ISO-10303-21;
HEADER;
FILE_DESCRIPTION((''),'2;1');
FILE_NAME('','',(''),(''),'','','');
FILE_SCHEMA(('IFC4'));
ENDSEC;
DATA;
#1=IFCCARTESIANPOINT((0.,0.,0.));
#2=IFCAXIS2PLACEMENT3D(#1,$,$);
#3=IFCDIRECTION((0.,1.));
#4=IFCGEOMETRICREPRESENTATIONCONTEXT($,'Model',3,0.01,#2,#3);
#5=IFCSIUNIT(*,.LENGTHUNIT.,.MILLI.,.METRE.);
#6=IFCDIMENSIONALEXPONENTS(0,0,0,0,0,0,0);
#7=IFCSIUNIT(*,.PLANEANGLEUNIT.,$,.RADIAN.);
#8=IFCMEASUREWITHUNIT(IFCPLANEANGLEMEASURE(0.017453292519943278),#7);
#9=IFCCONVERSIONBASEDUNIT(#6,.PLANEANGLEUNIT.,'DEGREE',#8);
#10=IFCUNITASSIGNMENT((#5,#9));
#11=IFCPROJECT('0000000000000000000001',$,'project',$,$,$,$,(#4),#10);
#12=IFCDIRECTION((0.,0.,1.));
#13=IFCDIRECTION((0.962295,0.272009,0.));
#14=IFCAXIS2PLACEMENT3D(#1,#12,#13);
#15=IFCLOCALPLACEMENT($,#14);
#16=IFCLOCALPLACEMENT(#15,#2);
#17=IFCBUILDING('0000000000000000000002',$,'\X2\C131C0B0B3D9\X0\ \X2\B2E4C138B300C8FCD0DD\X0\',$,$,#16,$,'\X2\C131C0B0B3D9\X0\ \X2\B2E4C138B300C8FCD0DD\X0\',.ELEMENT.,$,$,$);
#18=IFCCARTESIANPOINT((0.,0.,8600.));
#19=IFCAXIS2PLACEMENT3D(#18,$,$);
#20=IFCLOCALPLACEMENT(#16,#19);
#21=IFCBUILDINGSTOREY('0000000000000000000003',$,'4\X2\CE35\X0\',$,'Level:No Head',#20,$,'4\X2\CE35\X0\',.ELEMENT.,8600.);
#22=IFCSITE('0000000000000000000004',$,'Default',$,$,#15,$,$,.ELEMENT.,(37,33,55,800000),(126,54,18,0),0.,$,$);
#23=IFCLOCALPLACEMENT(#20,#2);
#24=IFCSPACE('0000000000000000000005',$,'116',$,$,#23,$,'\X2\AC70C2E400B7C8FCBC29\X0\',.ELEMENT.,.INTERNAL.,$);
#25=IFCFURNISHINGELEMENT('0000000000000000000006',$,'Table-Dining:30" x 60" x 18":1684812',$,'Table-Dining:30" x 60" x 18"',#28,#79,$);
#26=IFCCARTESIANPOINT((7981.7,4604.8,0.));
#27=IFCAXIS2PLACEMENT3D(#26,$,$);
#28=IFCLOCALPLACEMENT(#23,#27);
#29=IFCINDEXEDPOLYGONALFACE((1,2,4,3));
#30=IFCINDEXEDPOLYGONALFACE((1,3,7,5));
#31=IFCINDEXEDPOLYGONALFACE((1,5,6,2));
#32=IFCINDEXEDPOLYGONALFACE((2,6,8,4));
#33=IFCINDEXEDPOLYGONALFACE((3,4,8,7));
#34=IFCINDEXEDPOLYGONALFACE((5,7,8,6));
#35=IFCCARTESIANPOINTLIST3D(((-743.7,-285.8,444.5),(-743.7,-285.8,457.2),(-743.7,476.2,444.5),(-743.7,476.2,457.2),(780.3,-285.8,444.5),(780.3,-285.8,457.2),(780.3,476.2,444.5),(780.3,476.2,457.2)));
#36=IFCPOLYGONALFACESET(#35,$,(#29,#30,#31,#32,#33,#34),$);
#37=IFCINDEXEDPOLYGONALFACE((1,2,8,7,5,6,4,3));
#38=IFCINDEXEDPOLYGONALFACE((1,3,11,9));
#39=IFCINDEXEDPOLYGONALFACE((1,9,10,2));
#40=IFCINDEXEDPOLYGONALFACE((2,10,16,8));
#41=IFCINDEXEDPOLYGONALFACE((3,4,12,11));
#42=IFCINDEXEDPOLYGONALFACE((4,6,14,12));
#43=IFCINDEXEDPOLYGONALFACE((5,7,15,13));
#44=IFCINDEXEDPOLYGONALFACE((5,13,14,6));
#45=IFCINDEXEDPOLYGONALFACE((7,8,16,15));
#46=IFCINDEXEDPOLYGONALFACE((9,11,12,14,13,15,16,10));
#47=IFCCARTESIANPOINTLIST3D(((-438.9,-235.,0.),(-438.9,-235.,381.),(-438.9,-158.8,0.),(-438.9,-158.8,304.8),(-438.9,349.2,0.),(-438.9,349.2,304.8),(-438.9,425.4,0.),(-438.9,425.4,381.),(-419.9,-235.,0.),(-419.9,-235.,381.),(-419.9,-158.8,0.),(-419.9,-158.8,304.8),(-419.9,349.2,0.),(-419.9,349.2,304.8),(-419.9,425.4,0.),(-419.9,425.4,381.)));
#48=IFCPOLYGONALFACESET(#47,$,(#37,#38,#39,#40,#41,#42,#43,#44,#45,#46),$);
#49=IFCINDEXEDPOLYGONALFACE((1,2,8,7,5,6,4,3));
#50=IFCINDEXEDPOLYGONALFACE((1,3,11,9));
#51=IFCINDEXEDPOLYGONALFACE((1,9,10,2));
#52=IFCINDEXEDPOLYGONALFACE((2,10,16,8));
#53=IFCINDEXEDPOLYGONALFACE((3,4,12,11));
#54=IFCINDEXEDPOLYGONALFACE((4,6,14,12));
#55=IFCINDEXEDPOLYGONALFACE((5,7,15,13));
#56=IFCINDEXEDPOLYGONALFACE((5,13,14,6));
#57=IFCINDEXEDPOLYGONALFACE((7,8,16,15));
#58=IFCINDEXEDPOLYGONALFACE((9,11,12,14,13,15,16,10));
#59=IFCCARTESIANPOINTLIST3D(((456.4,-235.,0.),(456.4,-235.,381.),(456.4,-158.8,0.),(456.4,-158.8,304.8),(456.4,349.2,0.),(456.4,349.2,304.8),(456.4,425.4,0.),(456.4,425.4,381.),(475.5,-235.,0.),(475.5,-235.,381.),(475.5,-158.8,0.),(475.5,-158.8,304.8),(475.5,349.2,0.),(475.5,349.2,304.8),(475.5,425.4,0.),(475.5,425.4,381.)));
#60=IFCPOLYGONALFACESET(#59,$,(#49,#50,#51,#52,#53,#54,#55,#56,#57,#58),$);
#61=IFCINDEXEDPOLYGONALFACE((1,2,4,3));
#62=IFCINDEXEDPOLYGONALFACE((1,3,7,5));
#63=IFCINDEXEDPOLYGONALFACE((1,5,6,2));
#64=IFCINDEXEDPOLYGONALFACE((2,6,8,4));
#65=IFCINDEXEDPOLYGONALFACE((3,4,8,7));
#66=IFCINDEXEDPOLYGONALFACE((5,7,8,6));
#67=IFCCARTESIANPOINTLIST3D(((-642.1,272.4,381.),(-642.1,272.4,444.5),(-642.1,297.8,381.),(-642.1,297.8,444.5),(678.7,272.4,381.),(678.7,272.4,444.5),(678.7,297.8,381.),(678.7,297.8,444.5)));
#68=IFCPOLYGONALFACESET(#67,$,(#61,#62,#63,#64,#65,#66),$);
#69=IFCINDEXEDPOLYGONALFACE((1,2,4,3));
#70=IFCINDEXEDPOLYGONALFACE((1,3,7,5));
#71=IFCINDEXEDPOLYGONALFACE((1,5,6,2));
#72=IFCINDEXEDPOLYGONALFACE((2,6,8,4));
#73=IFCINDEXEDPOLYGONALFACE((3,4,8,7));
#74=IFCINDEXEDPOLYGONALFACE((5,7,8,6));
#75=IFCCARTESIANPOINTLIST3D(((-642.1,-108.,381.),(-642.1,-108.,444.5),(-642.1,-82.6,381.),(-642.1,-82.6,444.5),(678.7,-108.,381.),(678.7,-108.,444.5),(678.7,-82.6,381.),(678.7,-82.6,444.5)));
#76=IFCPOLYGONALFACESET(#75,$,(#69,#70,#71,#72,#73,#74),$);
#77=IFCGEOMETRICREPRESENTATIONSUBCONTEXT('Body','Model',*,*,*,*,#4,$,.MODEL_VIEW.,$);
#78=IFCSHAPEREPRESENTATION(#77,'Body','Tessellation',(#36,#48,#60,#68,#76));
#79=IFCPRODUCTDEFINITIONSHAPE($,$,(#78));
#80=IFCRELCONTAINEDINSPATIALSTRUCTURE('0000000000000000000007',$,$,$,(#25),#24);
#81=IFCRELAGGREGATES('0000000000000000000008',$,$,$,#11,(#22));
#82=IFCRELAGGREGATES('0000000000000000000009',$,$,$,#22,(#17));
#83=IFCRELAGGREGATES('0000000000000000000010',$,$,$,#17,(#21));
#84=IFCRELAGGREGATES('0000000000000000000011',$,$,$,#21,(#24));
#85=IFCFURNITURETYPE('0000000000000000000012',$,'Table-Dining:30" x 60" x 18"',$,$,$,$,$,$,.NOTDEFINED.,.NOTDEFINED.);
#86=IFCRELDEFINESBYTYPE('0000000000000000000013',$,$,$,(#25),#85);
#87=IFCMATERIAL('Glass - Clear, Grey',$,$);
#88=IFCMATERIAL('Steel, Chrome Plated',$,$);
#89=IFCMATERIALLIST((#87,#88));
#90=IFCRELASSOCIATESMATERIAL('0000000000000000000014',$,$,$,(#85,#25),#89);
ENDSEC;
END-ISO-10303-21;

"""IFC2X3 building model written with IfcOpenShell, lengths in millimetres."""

from ifc_helpers import new_model, entity, si_unit, converted_unit, direction, frame, frame_2d, origin, origin_2d_with_axis, place, context, subcontext, project, spatial, polyline, rectangle, outline, extrude, source, transform, mapped, material, material_list, type_object, type_shapes, element, save


model = new_model("IFC2X3")

# Units and contexts
model_context = context("Model", 3, precision=0.01, world=origin(), true_north=direction((0.0, 1.0)))
body_context = subcontext(model_context, "Body", "Model", "MODEL_VIEW")
ifc_project = project(units=[si_unit("LENGTHUNIT", "METRE", prefix="MILLI"), converted_unit("PLANEANGLEUNIT", "DEGREE", entity("IfcPlaneAngleMeasure", 0.017453292519943278), si_unit("PLANEANGLEUNIT", "RADIAN"), dimensions=[0, 0, 0, 0, 0, 0, 0])], contexts=[model_context])

# Site, building, storey
site_placement = place(None, frame((0.0, 0.0, 0.0), z_axis=(0.0, 0.0, 1.0), x_axis=(0.962295, 0.272009, 0.0)))
site = spatial("IfcSite", under=ifc_project, at=site_placement, Name="Default", CompositionType="ELEMENT", RefLatitude=(37, 33, 55, 800000), RefLongitude=(126, 54, 18, 0), RefElevation=0.0)
building_placement = place(site_placement, origin())
building = spatial("IfcBuilding", under=site, at=building_placement, Name="성산동 다세대주택", LongName="성산동 다세대주택", CompositionType="ELEMENT")
storey_placement = place(building_placement, frame((0.0, 0.0, 8600.0)))
storey = spatial("IfcBuildingStorey", under=building, at=storey_placement, Name="4층", ObjectType="Level:No Head", LongName="4층", CompositionType="ELEMENT", Elevation=8600.0)

# Shared definitions
space_1_placement = place(storey_placement, origin())
space_1 = spatial("IfcSpace", under=storey, at=space_1_placement, Name="116", LongName="거실·주방", CompositionType="ELEMENT", InteriorOrExteriorSpace="INTERNAL")

# Furnishing element
ifc_material_1 = material(Name="Glass - Clear, Grey")
ifc_material_2 = material(Name="Steel, Chrome Plated")
ifc_material_list_1 = material_list([ifc_material_1, ifc_material_2])
furniture_type_1 = type_object("IfcFurnitureType", Name="Table-Dining:30\" x 60\" x 18\"", AssemblyPlace="NOTDEFINED", material=ifc_material_list_1)
shared_shape_1 = source(origin(), body_context, "Body", "SweptSolid", [
    extrude(rectangle(XDim=1524.0, YDim=762.0, at=frame_2d((0.0, 0.0), x_axis=(1.0, 0.0))), frame((18.3, 95.2, 444.5), z_axis=(0.0, 0.0, 1.0), x_axis=(-1.0, 0.0, 0.0)), (0.0, 0.0, 1.0), 12.7),
    extrude(outline(polyline([(-330.2, -209.5), (330.2, -209.5), (330.2, 171.4), (254.0, 171.4), (254.0, -133.3), (-254.0, -133.3), (-254.0, 171.4), (-330.2, 171.4), (-330.2, -209.5)])), frame((-438.9, 95.2, 171.4), z_axis=(1.0, 0.0, 0.0), x_axis=(0.0, -1.0, 0.0)), (0.0, 0.0, 1.0), 19.1),
    extrude(outline(polyline([(-171.4, -330.2), (209.5, -330.2), (209.5, 330.2), (-171.4, 330.2), (-171.4, 254.0), (133.3, 254.0), (133.3, -254.0), (-171.4, -254.0), (-171.4, -330.2)])), frame((456.4, 95.2, 171.4), z_axis=(1.0, 0.0, 0.0), x_axis=(0.0, 0.0, 1.0)), (0.0, 0.0, 1.0), 19.1),
    extrude(rectangle(XDim=1320.8, YDim=25.4, at=frame_2d((0.0, 0.0), x_axis=(1.0, 0.0))), frame((18.3, 285.1, 381.0), z_axis=(0.0, 0.0, 1.0), x_axis=(-1.0, 0.0, 0.0)), (0.0, 0.0, 1.0), 63.5),
    extrude(rectangle(XDim=1320.8, YDim=25.4, at=origin_2d_with_axis()), frame((18.3, -95.3, 381.0), z_axis=(0.0, 0.0, 1.0), x_axis=(-1.0, 0.0, 0.0)), (0.0, 0.0, 1.0), 63.5),
])
type_shapes(furniture_type_1, [shared_shape_1])
furnishing_1_placement = place(space_1_placement, frame((7981.7, 4604.8, 0.0)))
element("IfcFurnishingElement", 1, at=furnishing_1_placement, inside=space_1, type_object=furniture_type_1, material=ifc_material_list_1, Name="Table-Dining:30\" x 60\" x 18\":1684812", ObjectType="Table-Dining:30\" x 60\" x 18\"", context=body_context, shape_type="MappedRepresentation", body=[
    mapped(shared_shape_1, transform((0.0, 0.0, 0.0), scale=1.0)),
])

save(model, "model.ifc")
